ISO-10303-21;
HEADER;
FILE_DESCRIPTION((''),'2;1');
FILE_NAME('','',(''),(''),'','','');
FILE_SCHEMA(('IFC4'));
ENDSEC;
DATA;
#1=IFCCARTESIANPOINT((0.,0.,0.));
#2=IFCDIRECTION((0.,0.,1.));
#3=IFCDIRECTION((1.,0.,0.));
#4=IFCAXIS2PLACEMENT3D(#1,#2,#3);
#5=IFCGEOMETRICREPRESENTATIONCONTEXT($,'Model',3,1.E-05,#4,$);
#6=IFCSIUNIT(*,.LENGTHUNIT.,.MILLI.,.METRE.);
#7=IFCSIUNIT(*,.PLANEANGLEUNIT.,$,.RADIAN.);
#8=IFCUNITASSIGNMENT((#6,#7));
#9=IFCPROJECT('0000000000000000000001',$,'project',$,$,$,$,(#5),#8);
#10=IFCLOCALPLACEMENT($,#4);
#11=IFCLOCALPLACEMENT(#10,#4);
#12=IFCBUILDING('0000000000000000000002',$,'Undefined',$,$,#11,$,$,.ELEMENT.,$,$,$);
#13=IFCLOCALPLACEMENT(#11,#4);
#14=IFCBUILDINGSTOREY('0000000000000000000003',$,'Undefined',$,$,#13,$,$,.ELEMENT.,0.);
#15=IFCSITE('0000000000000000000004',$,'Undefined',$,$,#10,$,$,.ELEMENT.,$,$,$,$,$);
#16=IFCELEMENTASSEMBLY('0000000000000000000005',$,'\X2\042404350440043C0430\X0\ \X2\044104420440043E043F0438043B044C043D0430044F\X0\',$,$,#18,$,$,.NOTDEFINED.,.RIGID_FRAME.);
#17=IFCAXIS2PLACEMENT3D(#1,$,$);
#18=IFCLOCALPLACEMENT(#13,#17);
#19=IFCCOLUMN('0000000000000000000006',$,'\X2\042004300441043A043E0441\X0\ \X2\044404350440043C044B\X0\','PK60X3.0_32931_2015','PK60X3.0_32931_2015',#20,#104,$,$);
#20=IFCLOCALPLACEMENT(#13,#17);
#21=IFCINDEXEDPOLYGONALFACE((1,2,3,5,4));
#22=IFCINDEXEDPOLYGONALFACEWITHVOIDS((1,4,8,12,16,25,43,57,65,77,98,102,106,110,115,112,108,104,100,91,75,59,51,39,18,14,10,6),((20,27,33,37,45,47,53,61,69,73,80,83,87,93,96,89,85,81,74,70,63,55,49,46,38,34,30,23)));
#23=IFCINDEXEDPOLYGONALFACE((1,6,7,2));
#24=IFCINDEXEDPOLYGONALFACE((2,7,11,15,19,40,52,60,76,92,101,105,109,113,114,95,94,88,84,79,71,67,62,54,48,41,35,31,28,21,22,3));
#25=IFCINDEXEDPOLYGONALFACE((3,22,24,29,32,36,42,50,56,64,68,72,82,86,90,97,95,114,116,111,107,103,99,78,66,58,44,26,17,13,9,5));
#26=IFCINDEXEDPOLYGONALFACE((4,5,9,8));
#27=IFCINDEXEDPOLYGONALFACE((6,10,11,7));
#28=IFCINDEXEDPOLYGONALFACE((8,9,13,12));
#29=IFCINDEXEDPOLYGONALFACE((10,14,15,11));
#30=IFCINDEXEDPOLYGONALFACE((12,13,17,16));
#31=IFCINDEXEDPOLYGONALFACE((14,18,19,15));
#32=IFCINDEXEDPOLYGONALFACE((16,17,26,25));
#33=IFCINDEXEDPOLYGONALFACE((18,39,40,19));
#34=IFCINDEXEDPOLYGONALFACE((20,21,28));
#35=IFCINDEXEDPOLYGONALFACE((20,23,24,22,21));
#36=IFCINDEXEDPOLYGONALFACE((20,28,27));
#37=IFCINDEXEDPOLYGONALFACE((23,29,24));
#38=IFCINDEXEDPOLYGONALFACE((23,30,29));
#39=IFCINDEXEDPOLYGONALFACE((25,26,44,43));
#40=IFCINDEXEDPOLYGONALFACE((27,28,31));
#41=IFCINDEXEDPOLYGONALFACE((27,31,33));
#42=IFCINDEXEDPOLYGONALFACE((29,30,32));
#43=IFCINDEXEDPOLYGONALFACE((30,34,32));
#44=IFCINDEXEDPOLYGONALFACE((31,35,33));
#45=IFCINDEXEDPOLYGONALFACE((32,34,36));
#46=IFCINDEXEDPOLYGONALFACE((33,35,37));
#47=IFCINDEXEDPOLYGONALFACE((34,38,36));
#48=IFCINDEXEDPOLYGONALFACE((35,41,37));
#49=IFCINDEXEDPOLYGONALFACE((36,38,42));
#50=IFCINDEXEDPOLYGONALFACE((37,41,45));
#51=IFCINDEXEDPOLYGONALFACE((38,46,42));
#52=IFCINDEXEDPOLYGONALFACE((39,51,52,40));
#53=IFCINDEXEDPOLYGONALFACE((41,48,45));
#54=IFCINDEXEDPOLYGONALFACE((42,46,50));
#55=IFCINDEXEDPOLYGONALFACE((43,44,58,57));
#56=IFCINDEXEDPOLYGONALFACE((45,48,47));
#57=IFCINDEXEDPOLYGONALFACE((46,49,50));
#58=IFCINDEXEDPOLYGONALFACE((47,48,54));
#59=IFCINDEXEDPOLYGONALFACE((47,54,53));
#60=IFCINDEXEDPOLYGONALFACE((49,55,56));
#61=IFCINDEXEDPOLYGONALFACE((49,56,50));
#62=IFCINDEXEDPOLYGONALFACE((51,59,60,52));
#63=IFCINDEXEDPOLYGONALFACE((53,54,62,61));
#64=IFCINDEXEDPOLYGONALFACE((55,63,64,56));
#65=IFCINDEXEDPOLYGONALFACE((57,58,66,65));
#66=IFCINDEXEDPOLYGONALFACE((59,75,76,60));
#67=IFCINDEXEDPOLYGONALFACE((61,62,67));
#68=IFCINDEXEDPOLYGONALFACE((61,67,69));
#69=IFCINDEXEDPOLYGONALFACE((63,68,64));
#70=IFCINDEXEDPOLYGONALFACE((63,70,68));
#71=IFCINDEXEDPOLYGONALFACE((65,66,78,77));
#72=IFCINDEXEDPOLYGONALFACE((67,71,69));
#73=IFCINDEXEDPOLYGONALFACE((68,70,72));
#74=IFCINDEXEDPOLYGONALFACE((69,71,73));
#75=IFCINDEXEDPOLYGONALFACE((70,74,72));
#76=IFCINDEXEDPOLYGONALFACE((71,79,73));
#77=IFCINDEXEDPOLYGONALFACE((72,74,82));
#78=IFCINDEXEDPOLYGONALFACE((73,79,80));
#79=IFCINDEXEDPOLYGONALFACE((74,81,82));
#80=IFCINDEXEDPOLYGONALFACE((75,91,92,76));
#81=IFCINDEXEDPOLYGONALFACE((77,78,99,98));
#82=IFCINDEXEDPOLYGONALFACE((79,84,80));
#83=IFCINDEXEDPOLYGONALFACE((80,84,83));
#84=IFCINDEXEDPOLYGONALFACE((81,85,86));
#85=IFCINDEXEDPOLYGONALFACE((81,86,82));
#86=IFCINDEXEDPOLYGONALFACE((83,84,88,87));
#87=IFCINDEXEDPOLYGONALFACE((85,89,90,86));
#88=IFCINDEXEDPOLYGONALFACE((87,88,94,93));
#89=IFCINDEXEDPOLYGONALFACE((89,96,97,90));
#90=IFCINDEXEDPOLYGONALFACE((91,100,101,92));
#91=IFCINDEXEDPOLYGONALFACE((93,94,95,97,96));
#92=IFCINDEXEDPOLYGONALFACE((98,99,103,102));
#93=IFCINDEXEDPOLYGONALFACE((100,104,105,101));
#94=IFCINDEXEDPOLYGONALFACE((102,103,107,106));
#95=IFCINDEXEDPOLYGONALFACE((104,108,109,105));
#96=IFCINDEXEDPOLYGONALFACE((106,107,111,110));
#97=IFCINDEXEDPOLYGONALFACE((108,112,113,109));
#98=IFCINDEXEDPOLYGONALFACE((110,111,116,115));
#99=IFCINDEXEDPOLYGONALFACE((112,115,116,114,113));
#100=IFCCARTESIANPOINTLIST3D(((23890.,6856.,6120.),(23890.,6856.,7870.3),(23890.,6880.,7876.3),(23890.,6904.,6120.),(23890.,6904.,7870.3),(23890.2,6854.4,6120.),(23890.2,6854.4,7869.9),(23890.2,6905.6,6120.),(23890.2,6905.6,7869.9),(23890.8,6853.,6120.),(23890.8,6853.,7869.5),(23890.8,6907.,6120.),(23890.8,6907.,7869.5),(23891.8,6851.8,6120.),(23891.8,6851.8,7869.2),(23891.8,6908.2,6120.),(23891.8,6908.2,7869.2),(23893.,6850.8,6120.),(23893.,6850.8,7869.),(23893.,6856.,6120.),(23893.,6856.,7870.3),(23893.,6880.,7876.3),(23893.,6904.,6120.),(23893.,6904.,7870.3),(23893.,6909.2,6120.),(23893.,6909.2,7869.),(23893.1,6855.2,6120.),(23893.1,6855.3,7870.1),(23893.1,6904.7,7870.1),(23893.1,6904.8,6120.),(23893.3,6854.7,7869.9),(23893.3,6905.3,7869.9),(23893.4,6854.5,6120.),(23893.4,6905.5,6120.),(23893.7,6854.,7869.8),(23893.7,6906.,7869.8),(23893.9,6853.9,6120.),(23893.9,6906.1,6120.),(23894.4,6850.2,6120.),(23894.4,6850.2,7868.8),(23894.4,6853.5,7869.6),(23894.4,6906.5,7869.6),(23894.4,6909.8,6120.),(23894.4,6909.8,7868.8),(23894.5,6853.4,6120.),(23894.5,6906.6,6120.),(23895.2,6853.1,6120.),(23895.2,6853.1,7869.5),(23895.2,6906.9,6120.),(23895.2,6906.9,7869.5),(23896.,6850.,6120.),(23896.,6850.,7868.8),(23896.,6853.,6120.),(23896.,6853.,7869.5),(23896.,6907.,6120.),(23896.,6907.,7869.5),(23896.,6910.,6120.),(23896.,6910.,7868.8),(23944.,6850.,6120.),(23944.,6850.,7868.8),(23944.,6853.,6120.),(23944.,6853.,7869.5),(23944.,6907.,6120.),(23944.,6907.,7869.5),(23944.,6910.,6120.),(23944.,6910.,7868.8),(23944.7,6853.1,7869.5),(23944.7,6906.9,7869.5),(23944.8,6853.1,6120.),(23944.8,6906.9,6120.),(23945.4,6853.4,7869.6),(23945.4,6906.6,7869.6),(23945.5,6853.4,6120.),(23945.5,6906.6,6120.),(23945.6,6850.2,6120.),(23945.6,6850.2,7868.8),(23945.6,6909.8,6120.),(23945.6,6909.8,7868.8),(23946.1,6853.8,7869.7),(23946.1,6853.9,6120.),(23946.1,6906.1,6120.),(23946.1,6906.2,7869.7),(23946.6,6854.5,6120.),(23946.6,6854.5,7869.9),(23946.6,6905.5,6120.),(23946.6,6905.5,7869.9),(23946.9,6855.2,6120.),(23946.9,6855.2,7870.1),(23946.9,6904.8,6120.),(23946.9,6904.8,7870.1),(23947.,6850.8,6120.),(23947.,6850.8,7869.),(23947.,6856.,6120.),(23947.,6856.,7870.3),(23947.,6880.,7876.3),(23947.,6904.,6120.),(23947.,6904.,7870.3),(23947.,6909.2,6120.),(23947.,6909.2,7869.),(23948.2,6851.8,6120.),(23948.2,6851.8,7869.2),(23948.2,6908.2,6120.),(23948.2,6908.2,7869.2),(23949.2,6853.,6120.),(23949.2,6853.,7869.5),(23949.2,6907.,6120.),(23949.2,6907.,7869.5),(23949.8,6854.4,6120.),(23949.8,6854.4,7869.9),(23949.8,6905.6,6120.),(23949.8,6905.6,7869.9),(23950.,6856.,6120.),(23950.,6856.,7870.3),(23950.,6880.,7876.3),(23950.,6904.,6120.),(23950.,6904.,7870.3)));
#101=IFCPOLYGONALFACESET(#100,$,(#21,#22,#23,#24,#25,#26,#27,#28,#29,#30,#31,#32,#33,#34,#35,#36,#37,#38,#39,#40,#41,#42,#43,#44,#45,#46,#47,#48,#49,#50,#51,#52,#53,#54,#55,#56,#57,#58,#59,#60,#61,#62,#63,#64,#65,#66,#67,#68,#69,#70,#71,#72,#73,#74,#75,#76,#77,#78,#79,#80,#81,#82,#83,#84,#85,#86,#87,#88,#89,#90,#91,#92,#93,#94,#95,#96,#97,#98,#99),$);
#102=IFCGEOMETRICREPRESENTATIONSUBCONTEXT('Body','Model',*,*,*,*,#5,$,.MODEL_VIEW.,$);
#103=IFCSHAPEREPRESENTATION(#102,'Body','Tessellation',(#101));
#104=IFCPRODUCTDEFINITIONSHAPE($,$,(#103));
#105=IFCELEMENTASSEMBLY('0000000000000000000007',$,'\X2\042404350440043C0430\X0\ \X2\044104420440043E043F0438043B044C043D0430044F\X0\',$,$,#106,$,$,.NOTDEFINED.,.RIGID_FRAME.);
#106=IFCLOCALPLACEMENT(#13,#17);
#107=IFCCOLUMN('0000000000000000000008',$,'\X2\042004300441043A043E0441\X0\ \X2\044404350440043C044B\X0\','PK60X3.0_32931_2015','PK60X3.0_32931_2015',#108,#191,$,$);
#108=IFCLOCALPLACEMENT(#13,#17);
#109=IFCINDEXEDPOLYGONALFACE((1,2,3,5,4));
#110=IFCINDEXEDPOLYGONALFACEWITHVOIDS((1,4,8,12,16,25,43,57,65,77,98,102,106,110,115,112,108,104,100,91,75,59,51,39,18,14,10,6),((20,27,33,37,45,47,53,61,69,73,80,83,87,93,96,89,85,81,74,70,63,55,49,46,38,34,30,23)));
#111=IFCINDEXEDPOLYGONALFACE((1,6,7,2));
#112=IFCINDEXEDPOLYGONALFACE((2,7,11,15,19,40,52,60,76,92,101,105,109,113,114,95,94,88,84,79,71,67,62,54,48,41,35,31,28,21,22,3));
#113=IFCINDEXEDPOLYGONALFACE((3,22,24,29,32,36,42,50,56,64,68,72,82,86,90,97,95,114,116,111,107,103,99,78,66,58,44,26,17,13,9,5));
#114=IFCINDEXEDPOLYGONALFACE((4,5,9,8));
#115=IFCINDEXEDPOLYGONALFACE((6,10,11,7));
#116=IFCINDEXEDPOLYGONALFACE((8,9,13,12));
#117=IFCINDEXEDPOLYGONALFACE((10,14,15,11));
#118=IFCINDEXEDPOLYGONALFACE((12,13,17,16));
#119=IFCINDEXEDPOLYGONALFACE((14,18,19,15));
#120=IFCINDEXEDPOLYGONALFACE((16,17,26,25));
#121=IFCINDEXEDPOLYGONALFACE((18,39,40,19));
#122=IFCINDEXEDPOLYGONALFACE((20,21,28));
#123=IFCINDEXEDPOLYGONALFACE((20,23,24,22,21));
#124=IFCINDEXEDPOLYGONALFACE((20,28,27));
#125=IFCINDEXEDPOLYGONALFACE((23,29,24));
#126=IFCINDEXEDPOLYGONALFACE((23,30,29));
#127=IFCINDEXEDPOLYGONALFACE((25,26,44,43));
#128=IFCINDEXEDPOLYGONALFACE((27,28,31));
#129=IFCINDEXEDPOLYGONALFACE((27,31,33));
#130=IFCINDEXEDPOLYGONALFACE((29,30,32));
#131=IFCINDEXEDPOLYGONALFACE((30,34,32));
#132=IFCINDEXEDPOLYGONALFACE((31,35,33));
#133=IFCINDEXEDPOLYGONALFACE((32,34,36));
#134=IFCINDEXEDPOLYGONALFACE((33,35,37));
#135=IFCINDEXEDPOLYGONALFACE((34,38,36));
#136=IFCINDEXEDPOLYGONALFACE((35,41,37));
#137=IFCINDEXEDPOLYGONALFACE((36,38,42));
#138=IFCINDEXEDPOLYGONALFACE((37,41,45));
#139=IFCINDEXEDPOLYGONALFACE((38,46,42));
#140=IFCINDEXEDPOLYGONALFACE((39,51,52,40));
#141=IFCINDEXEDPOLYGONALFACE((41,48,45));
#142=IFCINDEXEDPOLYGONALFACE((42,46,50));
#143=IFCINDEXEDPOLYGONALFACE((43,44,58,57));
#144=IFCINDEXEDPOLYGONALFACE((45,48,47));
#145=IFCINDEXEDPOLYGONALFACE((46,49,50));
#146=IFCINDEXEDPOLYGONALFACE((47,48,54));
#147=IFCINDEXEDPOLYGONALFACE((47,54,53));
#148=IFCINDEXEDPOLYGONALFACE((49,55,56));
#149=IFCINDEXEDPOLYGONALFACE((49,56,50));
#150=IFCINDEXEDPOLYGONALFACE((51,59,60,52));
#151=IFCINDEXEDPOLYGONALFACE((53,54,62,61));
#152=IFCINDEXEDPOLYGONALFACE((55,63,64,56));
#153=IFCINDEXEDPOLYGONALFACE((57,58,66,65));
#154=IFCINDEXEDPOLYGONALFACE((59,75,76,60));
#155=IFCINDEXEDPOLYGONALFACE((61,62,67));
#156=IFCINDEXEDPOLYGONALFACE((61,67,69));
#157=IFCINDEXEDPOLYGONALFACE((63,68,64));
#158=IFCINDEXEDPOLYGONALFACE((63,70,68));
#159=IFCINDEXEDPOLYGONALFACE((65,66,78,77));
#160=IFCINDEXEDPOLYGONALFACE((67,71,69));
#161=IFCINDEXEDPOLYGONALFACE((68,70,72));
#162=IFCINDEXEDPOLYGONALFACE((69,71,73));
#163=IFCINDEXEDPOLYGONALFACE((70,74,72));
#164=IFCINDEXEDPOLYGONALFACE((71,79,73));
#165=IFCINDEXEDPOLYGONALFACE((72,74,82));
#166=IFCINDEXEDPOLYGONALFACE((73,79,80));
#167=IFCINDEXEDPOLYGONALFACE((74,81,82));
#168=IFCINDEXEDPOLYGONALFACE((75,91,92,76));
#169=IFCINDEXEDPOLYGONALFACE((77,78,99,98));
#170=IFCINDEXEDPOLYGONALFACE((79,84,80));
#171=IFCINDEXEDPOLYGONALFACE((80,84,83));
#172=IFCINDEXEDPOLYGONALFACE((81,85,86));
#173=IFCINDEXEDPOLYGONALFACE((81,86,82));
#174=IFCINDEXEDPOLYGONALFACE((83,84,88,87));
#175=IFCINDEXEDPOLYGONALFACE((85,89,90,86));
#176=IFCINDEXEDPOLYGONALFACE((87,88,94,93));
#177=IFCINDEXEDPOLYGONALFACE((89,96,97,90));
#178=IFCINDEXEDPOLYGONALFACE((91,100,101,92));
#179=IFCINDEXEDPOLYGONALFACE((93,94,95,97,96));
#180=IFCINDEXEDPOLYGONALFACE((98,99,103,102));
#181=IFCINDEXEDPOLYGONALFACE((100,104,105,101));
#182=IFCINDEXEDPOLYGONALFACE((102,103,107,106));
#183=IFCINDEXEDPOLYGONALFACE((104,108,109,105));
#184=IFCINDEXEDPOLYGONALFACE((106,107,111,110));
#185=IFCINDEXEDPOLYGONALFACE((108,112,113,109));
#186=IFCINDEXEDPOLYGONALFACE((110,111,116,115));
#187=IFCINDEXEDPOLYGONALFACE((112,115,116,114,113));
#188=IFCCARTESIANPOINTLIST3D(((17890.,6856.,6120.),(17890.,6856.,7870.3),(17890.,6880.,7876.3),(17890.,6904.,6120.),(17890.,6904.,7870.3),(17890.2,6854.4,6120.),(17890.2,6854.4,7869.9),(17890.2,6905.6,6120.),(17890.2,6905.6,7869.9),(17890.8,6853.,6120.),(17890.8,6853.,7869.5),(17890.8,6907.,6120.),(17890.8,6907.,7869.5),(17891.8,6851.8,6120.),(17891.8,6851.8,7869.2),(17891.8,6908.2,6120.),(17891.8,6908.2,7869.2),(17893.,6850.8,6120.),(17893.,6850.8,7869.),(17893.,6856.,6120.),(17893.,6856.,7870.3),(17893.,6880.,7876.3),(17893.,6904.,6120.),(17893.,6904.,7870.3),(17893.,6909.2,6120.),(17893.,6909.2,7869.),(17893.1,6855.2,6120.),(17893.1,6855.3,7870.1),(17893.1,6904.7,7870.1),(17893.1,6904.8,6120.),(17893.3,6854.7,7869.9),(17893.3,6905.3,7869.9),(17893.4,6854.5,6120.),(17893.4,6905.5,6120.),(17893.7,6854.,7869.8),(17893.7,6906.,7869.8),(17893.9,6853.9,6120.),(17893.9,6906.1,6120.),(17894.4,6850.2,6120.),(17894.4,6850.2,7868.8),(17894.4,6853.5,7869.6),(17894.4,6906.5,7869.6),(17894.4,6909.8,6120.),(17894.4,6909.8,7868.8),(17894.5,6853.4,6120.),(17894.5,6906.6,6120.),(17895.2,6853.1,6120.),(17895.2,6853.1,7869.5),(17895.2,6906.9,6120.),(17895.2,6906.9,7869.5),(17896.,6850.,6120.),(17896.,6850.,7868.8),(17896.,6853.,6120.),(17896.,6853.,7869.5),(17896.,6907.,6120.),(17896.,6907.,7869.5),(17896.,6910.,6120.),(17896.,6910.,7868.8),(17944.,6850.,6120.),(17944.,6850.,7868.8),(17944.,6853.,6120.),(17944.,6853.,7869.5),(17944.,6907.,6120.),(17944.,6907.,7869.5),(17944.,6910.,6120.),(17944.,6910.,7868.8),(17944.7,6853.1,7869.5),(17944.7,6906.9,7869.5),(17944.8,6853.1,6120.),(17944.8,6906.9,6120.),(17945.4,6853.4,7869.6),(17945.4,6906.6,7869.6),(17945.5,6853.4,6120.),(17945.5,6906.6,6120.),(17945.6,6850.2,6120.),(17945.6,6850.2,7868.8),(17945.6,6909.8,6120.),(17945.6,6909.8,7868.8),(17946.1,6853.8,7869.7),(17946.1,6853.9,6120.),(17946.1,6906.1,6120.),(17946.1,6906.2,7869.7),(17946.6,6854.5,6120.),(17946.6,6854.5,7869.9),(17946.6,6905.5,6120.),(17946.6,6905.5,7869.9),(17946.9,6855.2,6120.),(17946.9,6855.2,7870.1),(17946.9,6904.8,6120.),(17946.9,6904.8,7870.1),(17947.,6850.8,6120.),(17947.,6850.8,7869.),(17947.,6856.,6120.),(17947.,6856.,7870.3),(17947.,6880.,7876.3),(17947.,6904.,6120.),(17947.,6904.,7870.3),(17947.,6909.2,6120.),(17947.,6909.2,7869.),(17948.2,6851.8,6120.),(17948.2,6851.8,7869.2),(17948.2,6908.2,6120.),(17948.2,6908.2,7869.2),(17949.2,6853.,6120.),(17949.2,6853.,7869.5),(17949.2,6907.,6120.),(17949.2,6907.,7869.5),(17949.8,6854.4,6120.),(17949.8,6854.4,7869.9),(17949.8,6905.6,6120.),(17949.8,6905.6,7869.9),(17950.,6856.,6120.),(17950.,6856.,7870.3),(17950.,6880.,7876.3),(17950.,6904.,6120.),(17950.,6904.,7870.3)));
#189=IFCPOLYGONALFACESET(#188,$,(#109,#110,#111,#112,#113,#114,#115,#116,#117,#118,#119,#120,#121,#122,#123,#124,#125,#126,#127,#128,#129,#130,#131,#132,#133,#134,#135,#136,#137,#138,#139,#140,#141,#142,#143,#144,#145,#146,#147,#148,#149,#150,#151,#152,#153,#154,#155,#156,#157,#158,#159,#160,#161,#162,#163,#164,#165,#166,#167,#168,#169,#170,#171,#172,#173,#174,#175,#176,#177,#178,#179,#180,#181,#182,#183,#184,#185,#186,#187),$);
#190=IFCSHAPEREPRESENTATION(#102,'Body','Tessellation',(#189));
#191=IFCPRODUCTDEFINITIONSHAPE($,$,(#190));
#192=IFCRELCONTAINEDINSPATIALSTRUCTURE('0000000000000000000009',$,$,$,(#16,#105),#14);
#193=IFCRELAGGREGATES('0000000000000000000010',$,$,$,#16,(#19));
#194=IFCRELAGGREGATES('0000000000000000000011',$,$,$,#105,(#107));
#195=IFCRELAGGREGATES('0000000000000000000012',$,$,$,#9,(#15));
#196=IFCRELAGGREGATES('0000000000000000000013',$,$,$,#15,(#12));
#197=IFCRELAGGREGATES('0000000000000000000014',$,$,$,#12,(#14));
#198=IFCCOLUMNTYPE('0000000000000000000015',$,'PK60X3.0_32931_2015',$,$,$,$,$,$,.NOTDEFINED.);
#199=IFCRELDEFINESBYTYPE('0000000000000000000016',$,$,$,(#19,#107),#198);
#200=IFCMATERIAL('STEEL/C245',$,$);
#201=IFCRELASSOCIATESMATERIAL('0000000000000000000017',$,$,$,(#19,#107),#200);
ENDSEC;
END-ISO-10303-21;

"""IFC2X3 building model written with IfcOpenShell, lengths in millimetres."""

from ifc_helpers import new_model, si_unit, frame, origin_with_axes, origin_2d_with_axis, place, context, subcontext, project, spatial, hollow_rectangle, extrude, clip, halfspace, material, type_object, element, aggregate, save


model = new_model("IFC2X3")

# Units and contexts
model_context = context("Model", 3, precision=1e-05, world=origin_with_axes())
body_context = subcontext(model_context, "Body", "Model", "MODEL_VIEW")
ifc_project = project(units=[si_unit("LENGTHUNIT", "METRE", prefix="MILLI"), si_unit("PLANEANGLEUNIT", "RADIAN")], contexts=[model_context])

# Site, building, storey
site_placement = place(None, origin_with_axes())
site = spatial("IfcSite", under=ifc_project, at=site_placement, Name="Undefined", CompositionType="ELEMENT")
building_placement = place(site_placement, origin_with_axes())
building = spatial("IfcBuilding", under=site, at=building_placement, Name="Undefined", CompositionType="ELEMENT")
storey_placement = place(building_placement, origin_with_axes())
storey = spatial("IfcBuildingStorey", under=building, at=storey_placement, Name="Undefined", CompositionType="ELEMENT", Elevation=0.0)

# Shared definitions
ifc_material = material(Name="STEEL/C245")

# Element assemblies, columns
assembly_1_placement = place(storey_placement, origin_with_axes())
assembly_1 = element("IfcElementAssembly", 1, at=assembly_1_placement, inside=storey, Name="Ферма стропильная", AssemblyPlace="NOTDEFINED", PredefinedType="RIGID_FRAME")
column_type_1 = type_object("IfcColumnType", Name="PK60X3.0_32931_2015", PredefinedType="NOTDEFINED")
column_1_placement = place(assembly_1_placement, frame((23920.0, 6880.0, 6120.0), z_axis=(0.0, 0.0, 1.0), x_axis=(-1.0, 0.0, 0.0)))
column_1 = element("IfcColumn", 2, at=column_1_placement, type_object=column_type_1, material=ifc_material, Name="Раскос фермы", Description="PK60X3.0_32931_2015", ObjectType="PK60X3.0_32931_2015", context=body_context, shape_type="Clipping", body=[
    clip(clip(extrude(hollow_rectangle(XDim=60.0, YDim=60.0, WallThickness=3.0, InnerFilletRadius=3.0, OuterFilletRadius=6.0, at=origin_2d_with_axis()), frame((0.0, 0.0, 1756.3), z_axis=(0.0, 0.0, -1.0), x_axis=(0.0, 1.0, 0.0)), (0.0, 0.0, 1.0), 1756.3), halfspace(frame((-30.0, 30.0, 1763.8), z_axis=(0.0, -0.243188, 0.969979), x_axis=(1.0, 0.0, 0.0)), False)), halfspace(frame((0.0, 4455.7, 639.2), z_axis=(0.0, -0.243188, -0.969979), x_axis=(-1.0, 0.0, 0.0)), True)),
])
assembly_2_placement = place(storey_placement, origin_with_axes())
assembly_2 = element("IfcElementAssembly", 3, at=assembly_2_placement, inside=storey, Name="Ферма стропильная", AssemblyPlace="NOTDEFINED", PredefinedType="RIGID_FRAME")
column_2_placement = place(assembly_2_placement, frame((17920.0, 6880.0, 6120.0), z_axis=(0.0, 0.0, 1.0), x_axis=(-1.0, 0.0, 0.0)))
column_2 = element("IfcColumn", 4, at=column_2_placement, type_object=column_type_1, material=ifc_material, Name="Раскос фермы", Description="PK60X3.0_32931_2015", ObjectType="PK60X3.0_32931_2015", context=body_context, shape_type="Clipping", body=[
    clip(clip(extrude(hollow_rectangle(XDim=60.0, YDim=60.0, WallThickness=3.0, InnerFilletRadius=3.0, OuterFilletRadius=6.0, at=origin_2d_with_axis()), frame((0.0, 0.0, 1756.3), z_axis=(0.0, 0.0, -1.0), x_axis=(0.0, 1.0, 0.0)), (0.0, 0.0, 1.0), 1756.3), halfspace(frame((-30.0, 30.0, 1763.8), z_axis=(0.0, -0.243188, 0.969979), x_axis=(1.0, 0.0, 0.0)), False)), halfspace(frame((0.0, 4455.7, 639.2), z_axis=(0.0, -0.243188, -0.969979), x_axis=(-1.0, 0.0, 0.0)), True)),
])

aggregate(assembly_1, [column_1])
aggregate(assembly_2, [column_2])

save(model, "model.ifc")
